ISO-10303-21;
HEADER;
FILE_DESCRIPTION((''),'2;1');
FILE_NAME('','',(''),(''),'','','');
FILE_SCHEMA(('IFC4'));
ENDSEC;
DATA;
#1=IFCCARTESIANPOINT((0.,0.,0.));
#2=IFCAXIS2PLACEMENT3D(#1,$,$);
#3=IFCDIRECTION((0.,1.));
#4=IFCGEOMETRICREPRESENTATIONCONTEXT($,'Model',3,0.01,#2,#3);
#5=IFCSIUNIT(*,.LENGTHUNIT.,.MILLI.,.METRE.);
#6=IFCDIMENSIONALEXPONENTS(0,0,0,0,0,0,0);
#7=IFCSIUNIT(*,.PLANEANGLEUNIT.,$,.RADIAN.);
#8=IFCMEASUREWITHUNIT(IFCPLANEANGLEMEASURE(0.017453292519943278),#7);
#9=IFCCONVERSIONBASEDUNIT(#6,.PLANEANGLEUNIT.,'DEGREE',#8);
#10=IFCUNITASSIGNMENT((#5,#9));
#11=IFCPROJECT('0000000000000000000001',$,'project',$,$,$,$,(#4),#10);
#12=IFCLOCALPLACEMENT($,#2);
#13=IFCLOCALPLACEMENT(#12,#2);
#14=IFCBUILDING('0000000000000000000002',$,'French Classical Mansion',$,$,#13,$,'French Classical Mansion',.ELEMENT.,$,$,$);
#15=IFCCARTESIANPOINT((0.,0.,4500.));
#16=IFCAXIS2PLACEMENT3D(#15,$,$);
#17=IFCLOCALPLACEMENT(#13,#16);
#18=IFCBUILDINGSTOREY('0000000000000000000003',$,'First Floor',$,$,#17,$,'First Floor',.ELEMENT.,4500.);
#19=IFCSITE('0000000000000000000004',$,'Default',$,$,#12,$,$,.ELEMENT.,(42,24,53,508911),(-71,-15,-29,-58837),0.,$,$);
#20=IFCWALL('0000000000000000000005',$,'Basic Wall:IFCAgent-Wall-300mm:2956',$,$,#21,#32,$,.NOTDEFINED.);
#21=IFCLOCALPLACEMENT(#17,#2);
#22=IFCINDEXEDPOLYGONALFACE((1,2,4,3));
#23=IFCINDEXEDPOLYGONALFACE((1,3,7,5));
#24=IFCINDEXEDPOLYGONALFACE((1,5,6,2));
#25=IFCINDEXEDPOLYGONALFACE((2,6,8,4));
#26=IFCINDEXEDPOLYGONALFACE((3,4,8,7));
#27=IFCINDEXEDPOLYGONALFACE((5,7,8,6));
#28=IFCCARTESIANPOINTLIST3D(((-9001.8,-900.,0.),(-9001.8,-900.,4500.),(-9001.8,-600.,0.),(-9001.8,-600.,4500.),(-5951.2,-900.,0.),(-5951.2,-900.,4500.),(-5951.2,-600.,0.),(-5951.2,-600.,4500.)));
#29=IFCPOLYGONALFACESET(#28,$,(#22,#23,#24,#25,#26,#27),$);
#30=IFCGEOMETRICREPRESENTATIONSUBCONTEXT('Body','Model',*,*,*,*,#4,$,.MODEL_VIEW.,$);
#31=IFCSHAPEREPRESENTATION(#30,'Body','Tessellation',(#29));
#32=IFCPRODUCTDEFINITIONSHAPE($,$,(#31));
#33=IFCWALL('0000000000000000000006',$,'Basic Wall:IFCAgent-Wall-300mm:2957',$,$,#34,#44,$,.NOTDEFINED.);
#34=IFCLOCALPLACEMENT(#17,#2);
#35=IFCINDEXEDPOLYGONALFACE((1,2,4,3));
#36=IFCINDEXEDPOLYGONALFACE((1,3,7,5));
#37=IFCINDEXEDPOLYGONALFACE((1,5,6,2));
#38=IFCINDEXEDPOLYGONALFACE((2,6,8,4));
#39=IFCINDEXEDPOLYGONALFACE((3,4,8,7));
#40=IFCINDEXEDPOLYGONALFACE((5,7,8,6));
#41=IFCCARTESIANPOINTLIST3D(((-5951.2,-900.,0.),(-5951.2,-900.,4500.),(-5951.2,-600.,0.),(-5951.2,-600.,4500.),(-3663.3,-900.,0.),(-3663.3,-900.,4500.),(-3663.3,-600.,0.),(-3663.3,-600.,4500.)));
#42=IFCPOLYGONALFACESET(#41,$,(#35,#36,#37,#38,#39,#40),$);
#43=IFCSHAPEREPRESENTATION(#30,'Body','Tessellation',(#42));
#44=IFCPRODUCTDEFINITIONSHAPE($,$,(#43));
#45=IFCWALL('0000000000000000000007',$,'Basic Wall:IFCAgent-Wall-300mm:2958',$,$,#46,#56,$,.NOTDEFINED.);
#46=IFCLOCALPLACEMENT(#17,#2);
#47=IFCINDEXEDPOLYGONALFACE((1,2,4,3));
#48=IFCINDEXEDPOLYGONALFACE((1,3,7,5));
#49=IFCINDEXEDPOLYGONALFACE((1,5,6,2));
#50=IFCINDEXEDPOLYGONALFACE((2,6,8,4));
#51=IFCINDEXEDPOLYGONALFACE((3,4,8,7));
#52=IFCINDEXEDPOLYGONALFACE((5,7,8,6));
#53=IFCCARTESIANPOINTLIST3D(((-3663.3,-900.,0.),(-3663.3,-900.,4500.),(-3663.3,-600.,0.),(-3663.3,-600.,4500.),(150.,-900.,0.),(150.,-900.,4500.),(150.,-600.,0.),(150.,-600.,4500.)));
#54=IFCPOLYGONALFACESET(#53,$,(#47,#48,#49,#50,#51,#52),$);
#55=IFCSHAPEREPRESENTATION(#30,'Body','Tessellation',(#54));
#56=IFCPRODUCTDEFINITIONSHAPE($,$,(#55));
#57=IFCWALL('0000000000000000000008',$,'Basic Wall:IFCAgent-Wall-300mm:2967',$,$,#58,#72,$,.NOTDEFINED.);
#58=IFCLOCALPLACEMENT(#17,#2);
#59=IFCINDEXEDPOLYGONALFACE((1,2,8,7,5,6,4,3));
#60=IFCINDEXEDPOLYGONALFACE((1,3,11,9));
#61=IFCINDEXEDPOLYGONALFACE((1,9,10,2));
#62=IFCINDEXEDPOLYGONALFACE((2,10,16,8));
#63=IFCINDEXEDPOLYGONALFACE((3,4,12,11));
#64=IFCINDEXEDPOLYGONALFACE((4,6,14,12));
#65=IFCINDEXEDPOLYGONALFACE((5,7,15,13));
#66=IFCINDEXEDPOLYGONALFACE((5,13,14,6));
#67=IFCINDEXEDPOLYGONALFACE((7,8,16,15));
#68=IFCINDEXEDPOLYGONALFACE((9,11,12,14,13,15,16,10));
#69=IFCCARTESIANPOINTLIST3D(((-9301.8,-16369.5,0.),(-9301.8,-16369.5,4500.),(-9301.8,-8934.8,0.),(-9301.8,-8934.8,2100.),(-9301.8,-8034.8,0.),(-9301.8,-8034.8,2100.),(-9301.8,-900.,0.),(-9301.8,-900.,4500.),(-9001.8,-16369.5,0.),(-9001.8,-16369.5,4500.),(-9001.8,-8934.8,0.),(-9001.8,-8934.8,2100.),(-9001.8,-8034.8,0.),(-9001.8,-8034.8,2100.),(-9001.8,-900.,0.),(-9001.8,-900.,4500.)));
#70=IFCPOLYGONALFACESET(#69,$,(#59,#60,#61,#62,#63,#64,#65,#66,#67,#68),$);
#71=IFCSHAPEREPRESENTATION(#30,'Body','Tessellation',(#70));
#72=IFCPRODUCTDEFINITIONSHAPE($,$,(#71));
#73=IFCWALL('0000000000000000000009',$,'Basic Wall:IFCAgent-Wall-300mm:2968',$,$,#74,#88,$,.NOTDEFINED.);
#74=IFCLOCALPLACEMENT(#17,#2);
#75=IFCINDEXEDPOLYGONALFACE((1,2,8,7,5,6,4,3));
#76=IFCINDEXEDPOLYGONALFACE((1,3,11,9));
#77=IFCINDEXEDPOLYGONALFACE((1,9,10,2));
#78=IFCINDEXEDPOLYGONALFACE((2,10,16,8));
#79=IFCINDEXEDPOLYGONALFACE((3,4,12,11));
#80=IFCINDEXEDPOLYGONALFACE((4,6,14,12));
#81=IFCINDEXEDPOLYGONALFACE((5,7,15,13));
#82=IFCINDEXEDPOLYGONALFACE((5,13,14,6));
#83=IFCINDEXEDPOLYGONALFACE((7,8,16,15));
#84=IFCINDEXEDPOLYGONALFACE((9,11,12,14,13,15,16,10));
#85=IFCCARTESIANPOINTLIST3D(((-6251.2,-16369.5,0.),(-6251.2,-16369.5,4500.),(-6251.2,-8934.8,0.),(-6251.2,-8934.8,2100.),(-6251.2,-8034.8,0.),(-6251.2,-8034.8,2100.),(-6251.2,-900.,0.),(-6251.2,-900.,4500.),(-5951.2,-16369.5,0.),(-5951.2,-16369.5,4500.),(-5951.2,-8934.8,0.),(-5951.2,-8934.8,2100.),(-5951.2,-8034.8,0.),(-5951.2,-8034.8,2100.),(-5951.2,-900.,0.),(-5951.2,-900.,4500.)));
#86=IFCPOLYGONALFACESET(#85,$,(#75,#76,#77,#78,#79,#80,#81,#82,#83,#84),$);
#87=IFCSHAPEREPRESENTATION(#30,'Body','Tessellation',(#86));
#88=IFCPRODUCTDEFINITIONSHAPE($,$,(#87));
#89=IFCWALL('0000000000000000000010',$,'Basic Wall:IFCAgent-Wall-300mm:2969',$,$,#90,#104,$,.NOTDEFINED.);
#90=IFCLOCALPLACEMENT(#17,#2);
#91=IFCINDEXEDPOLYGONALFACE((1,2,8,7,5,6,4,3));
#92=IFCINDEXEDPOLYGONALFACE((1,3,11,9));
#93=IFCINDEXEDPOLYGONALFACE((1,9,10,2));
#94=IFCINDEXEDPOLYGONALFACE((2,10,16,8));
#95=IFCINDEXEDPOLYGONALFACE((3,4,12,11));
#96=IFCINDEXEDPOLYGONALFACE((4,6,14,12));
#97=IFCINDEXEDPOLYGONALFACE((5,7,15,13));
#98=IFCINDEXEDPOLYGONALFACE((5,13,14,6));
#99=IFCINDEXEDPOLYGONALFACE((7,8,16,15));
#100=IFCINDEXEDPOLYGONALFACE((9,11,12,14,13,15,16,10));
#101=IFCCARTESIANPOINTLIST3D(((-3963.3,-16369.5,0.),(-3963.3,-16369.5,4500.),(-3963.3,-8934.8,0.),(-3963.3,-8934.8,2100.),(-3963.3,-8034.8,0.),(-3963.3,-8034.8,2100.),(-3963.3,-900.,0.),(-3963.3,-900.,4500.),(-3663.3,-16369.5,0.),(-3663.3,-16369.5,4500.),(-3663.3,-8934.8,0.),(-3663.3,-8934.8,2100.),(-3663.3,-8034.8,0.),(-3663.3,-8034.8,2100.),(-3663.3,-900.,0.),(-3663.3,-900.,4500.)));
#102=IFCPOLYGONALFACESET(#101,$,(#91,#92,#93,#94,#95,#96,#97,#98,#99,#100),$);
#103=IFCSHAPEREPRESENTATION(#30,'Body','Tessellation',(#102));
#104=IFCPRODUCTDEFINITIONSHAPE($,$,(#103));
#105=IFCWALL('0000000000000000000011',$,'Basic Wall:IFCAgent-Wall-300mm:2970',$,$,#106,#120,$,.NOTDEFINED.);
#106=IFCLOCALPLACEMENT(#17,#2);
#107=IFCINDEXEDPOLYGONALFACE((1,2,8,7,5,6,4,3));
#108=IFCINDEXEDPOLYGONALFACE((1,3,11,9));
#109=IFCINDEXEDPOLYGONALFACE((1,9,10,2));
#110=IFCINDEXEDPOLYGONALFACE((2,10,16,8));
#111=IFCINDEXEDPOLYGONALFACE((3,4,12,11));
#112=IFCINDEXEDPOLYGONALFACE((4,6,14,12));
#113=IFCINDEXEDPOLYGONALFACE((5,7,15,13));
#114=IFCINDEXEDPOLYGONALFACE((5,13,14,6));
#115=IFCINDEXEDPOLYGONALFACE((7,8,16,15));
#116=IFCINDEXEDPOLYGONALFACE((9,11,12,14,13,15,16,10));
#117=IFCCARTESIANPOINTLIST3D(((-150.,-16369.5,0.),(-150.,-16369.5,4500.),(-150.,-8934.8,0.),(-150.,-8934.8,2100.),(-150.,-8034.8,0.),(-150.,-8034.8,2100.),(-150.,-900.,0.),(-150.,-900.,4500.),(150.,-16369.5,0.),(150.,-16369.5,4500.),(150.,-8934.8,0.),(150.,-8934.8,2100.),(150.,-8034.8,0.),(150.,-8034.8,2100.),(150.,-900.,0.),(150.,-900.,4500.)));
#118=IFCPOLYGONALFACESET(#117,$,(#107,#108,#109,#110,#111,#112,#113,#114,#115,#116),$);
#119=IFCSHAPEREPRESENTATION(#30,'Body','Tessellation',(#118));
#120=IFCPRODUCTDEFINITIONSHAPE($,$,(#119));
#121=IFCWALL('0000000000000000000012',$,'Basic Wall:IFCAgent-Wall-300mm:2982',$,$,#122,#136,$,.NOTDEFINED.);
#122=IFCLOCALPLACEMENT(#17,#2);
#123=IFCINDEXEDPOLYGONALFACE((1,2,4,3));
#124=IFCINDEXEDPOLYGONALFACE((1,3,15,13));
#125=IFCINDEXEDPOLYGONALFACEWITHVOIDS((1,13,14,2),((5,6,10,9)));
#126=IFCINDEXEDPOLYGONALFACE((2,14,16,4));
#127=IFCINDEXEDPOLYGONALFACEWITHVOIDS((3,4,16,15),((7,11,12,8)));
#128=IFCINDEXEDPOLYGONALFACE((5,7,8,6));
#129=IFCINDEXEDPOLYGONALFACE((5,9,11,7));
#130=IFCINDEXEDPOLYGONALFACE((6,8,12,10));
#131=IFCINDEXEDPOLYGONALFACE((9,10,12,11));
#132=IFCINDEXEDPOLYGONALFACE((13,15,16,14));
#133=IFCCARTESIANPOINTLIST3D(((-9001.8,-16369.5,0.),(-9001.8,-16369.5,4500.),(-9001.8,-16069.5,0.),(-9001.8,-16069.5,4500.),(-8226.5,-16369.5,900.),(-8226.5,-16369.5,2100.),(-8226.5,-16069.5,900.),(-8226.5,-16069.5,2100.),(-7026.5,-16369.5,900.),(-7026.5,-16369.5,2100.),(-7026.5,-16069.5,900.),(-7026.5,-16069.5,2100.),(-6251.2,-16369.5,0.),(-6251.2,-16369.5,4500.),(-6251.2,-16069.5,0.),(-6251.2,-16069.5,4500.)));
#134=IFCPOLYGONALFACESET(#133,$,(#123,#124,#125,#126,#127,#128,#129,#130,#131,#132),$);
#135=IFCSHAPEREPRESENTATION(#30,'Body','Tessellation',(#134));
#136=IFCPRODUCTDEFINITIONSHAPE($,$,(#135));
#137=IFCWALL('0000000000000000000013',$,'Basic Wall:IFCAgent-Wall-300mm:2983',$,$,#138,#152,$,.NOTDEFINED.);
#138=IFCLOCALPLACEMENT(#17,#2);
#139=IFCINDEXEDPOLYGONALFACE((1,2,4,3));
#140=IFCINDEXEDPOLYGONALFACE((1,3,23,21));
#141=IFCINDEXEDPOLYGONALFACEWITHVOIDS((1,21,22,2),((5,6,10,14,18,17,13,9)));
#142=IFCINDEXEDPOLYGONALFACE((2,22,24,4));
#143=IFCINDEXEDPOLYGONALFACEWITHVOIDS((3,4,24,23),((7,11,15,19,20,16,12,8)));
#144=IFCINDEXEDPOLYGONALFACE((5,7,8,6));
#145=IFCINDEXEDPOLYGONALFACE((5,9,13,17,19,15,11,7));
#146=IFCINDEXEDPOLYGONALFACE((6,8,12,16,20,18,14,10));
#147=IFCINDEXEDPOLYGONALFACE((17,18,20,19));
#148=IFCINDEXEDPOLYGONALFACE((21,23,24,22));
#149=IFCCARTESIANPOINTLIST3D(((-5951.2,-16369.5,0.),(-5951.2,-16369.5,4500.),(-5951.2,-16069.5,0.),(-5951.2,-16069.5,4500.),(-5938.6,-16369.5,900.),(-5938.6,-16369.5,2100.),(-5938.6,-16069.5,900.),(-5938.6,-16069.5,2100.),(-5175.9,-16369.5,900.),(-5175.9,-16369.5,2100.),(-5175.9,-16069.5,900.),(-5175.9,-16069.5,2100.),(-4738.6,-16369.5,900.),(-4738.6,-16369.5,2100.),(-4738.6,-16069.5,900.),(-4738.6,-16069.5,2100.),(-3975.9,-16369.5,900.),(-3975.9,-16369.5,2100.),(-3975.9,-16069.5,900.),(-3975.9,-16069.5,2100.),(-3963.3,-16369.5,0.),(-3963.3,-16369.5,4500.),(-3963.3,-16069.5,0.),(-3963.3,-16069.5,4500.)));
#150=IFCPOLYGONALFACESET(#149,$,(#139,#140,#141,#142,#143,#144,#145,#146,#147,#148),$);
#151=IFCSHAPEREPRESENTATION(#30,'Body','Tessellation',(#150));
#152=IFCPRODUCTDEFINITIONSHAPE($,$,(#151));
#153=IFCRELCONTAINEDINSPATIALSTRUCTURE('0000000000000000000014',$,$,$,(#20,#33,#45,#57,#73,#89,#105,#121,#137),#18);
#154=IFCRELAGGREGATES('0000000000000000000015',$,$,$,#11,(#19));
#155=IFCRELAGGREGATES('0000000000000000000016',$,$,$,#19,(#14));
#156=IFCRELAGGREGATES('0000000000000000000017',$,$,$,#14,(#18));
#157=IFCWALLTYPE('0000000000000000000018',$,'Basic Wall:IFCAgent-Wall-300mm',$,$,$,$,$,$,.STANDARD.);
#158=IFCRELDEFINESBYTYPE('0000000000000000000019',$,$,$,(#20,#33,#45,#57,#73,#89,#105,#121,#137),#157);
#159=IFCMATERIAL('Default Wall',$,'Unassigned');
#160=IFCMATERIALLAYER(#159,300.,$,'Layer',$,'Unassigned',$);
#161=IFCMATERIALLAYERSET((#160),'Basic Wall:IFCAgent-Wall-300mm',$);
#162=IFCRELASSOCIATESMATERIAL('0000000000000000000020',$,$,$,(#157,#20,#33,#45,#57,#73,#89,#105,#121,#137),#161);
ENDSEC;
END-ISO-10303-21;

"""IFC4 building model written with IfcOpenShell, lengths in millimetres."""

from ifc_helpers import new_model, entity, si_unit, converted_unit, direction, frame, frame_2d, origin, place, context, subcontext, project, spatial, rectangle, extrude, material, layer, layer_set, layer_usage, type_object, element, save


model = new_model("IFC4")

# Units and contexts
model_context = context("Model", 3, precision=0.01, world=origin(), true_north=direction((0.0, 1.0)))
body_context = subcontext(model_context, "Body", "Model", "MODEL_VIEW")
ifc_project = project(units=[si_unit("LENGTHUNIT", "METRE", prefix="MILLI"), converted_unit("PLANEANGLEUNIT", "DEGREE", entity("IfcPlaneAngleMeasure", 0.017453292519943278), si_unit("PLANEANGLEUNIT", "RADIAN"), dimensions=[0, 0, 0, 0, 0, 0, 0])], contexts=[model_context])

# Site, building, storey
site_placement = place(None, origin())
site = spatial("IfcSite", under=ifc_project, at=site_placement, Name="Default", CompositionType="ELEMENT", RefLatitude=(42, 24, 53, 508911), RefLongitude=(-71, -15, -29, -58837), RefElevation=0.0)
building_placement = place(site_placement, origin())
building = spatial("IfcBuilding", under=site, at=building_placement, Name="French Classical Mansion", LongName="French Classical Mansion", CompositionType="ELEMENT")
storey_placement = place(building_placement, frame((0.0, 0.0, 4500.0)))
storey = spatial("IfcBuildingStorey", under=building, at=storey_placement, Name="First Floor", LongName="First Floor", CompositionType="ELEMENT", Elevation=4500.0)

# Walls
ifc_material = material(Name="Default Wall", Category="Unassigned")
ifc_layer = layer(ifc_material, 300.0, Name="Layer", Category="Unassigned")
ifc_layer_set = layer_set([ifc_layer], Name="Basic Wall:IFCAgent-Wall-300mm")
ifc_layer_usage_1 = layer_usage(ifc_layer_set, "AXIS2", "NEGATIVE", 150.0)
wall_type = type_object("IfcWallType", Name="Basic Wall:IFCAgent-Wall-300mm", PredefinedType="STANDARD", material=ifc_layer_set)
wall_1_placement = place(storey_placement, frame((-9001.8, -750.0, 0.0)))
element("IfcWall", 1, at=wall_1_placement, inside=storey, type_object=wall_type, material=ifc_layer_usage_1, Name="Basic Wall:IFCAgent-Wall-300mm:2956", PredefinedType="NOTDEFINED", context=body_context, shape_type="SweptSolid", body=[
    extrude(rectangle(XDim=3050.6, YDim=300.0, at=frame_2d((1525.3, 0.0), x_axis=(-1.0, 0.0))), origin(), (0.0, 0.0, 1.0), 4500.0),
])
ifc_layer_usage_2 = layer_usage(ifc_layer_set, "AXIS2", "NEGATIVE", 150.0)
wall_2_placement = place(storey_placement, frame((-5951.2, -750.0, 0.0)))
element("IfcWall", 2, at=wall_2_placement, inside=storey, type_object=wall_type, material=ifc_layer_usage_2, Name="Basic Wall:IFCAgent-Wall-300mm:2957", PredefinedType="NOTDEFINED", context=body_context, shape_type="SweptSolid", body=[
    extrude(rectangle(XDim=2288.0, YDim=300.0, at=frame_2d((1144.0, 0.0), x_axis=(-1.0, 0.0))), origin(), (0.0, 0.0, 1.0), 4500.0),
])
ifc_layer_usage_3 = layer_usage(ifc_layer_set, "AXIS2", "NEGATIVE", 150.0)
wall_3_placement = place(storey_placement, frame((-3663.3, -750.0, 0.0)))
element("IfcWall", 3, at=wall_3_placement, inside=storey, type_object=wall_type, material=ifc_layer_usage_3, Name="Basic Wall:IFCAgent-Wall-300mm:2958", PredefinedType="NOTDEFINED", context=body_context, shape_type="SweptSolid", body=[
    extrude(rectangle(XDim=3813.3, YDim=300.0, at=frame_2d((1906.6, 0.0), x_axis=(-1.0, 0.0))), origin(), (0.0, 0.0, 1.0), 4500.0),
])

# Walls, openings
ifc_layer_usage_4 = layer_usage(ifc_layer_set, "AXIS2", "NEGATIVE", 150.0)
wall_4_placement = place(storey_placement, frame((-9151.8, -16369.5, 0.0), z_axis=(0.0, 0.0, 1.0), x_axis=(0.0, 1.0, 0.0)))
wall_4 = element("IfcWall", 4, at=wall_4_placement, inside=storey, type_object=wall_type, material=ifc_layer_usage_4, Name="Basic Wall:IFCAgent-Wall-300mm:2967", PredefinedType="NOTDEFINED", context=body_context, shape_type="SweptSolid", body=[
    extrude(rectangle(XDim=15469.5, YDim=300.0, at=frame_2d((7734.8, 0.0), x_axis=(1.0, 0.0))), origin(), (0.0, 0.0, 1.0), 4500.0),
])
opening_1_placement = place(wall_4_placement, origin())
element("IfcOpeningElement", 5, at=opening_1_placement, cuts=wall_4, PredefinedType="OPENING", context=body_context, shape_type="SweptSolid", body=[
    extrude(rectangle(XDim=2100.0, YDim=900.0, at=frame_2d((0.0, 0.0), x_axis=(1.0, 0.0))), frame((7884.7, -150.0, 1050.0), z_axis=(0.0, 1.0, 0.0), x_axis=(0.0, 0.0, -1.0)), (0.0, 0.0, 1.0), 300.0),
])
ifc_layer_usage_5 = layer_usage(ifc_layer_set, "AXIS2", "NEGATIVE", 150.0)
wall_5_placement = place(storey_placement, frame((-6101.2, -16369.5, 0.0), z_axis=(0.0, 0.0, 1.0), x_axis=(0.0, 1.0, 0.0)))
wall_5 = element("IfcWall", 6, at=wall_5_placement, inside=storey, type_object=wall_type, material=ifc_layer_usage_5, Name="Basic Wall:IFCAgent-Wall-300mm:2968", PredefinedType="NOTDEFINED", context=body_context, shape_type="SweptSolid", body=[
    extrude(rectangle(XDim=15469.5, YDim=300.0, at=frame_2d((7734.8, 0.0), x_axis=(1.0, 0.0))), origin(), (0.0, 0.0, 1.0), 4500.0),
])
opening_2_placement = place(wall_5_placement, origin())
element("IfcOpeningElement", 7, at=opening_2_placement, cuts=wall_5, PredefinedType="OPENING", context=body_context, shape_type="SweptSolid", body=[
    extrude(rectangle(XDim=2100.0, YDim=900.0, at=frame_2d((0.0, 0.0), x_axis=(1.0, 0.0))), frame((7884.7, -150.0, 1050.0), z_axis=(0.0, 1.0, 0.0), x_axis=(0.0, 0.0, -1.0)), (0.0, 0.0, 1.0), 300.0),
])
ifc_layer_usage_6 = layer_usage(ifc_layer_set, "AXIS2", "NEGATIVE", 150.0)
wall_6_placement = place(storey_placement, frame((-3813.3, -16369.5, 0.0), z_axis=(0.0, 0.0, 1.0), x_axis=(0.0, 1.0, 0.0)))
wall_6 = element("IfcWall", 8, at=wall_6_placement, inside=storey, type_object=wall_type, material=ifc_layer_usage_6, Name="Basic Wall:IFCAgent-Wall-300mm:2969", PredefinedType="NOTDEFINED", context=body_context, shape_type="SweptSolid", body=[
    extrude(rectangle(XDim=15469.5, YDim=300.0, at=frame_2d((7734.8, 0.0), x_axis=(1.0, 0.0))), origin(), (0.0, 0.0, 1.0), 4500.0),
])
opening_3_placement = place(wall_6_placement, origin())
element("IfcOpeningElement", 9, at=opening_3_placement, cuts=wall_6, PredefinedType="OPENING", context=body_context, shape_type="SweptSolid", body=[
    extrude(rectangle(XDim=2100.0, YDim=900.0, at=frame_2d((0.0, 0.0), x_axis=(1.0, 0.0))), frame((7884.7, -150.0, 1050.0), z_axis=(0.0, 1.0, 0.0), x_axis=(0.0, 0.0, -1.0)), (0.0, 0.0, 1.0), 300.0),
])
ifc_layer_usage_7 = layer_usage(ifc_layer_set, "AXIS2", "NEGATIVE", 150.0)
wall_7_placement = place(storey_placement, frame((0.0, -16369.5, 0.0), z_axis=(0.0, 0.0, 1.0), x_axis=(0.0, 1.0, 0.0)))
wall_7 = element("IfcWall", 10, at=wall_7_placement, inside=storey, type_object=wall_type, material=ifc_layer_usage_7, Name="Basic Wall:IFCAgent-Wall-300mm:2970", PredefinedType="NOTDEFINED", context=body_context, shape_type="SweptSolid", body=[
    extrude(rectangle(XDim=15469.5, YDim=300.0, at=frame_2d((7734.8, 0.0), x_axis=(1.0, 0.0))), origin(), (0.0, 0.0, 1.0), 4500.0),
])
opening_4_placement = place(wall_7_placement, origin())
element("IfcOpeningElement", 11, at=opening_4_placement, cuts=wall_7, PredefinedType="OPENING", context=body_context, shape_type="SweptSolid", body=[
    extrude(rectangle(XDim=2100.0, YDim=900.0, at=frame_2d((0.0, 0.0), x_axis=(1.0, 0.0))), frame((7884.7, -150.0, 1050.0), z_axis=(0.0, 1.0, 0.0), x_axis=(0.0, 0.0, -1.0)), (0.0, 0.0, 1.0), 300.0),
])
ifc_layer_usage_8 = layer_usage(ifc_layer_set, "AXIS2", "NEGATIVE", 150.0)
wall_8_placement = place(storey_placement, frame((-9001.8, -16219.5, 0.0)))
wall_8 = element("IfcWall", 12, at=wall_8_placement, inside=storey, type_object=wall_type, material=ifc_layer_usage_8, Name="Basic Wall:IFCAgent-Wall-300mm:2982", PredefinedType="NOTDEFINED", context=body_context, shape_type="SweptSolid", body=[
    extrude(rectangle(XDim=2750.6, YDim=300.0, at=frame_2d((1375.3, 0.0), x_axis=(-1.0, 0.0))), origin(), (0.0, 0.0, 1.0), 4500.0),
])
opening_5_placement = place(wall_8_placement, origin())
element("IfcOpeningElement", 13, at=opening_5_placement, cuts=wall_8, PredefinedType="OPENING", context=body_context, shape_type="SweptSolid", body=[
    extrude(rectangle(XDim=1200.0, YDim=1200.0, at=frame_2d((0.0, 0.0), x_axis=(1.0, 0.0))), frame((1375.3, -150.0, 1500.0), z_axis=(0.0, 1.0, 0.0), x_axis=(0.0, 0.0, -1.0)), (0.0, 0.0, 1.0), 300.0),
])

# Wall, openings
ifc_layer_usage_9 = layer_usage(ifc_layer_set, "AXIS2", "NEGATIVE", 150.0)
wall_9_placement = place(storey_placement, frame((-5951.2, -16219.5, 0.0)))
wall_9 = element("IfcWall", 14, at=wall_9_placement, inside=storey, type_object=wall_type, material=ifc_layer_usage_9, Name="Basic Wall:IFCAgent-Wall-300mm:2983", PredefinedType="NOTDEFINED", context=body_context, shape_type="SweptSolid", body=[
    extrude(rectangle(XDim=1988.0, YDim=300.0, at=frame_2d((994.0, 0.0), x_axis=(-1.0, 0.0))), origin(), (0.0, 0.0, 1.0), 4500.0),
])
opening_6_placement = place(wall_9_placement, origin())
element("IfcOpeningElement", 15, at=opening_6_placement, cuts=wall_9, PredefinedType="OPENING", context=body_context, shape_type="SweptSolid", body=[
    extrude(rectangle(XDim=1200.0, YDim=1200.0, at=frame_2d((0.0, 0.0), x_axis=(1.0, 0.0))), frame((612.7, -150.0, 1500.0), z_axis=(0.0, 1.0, 0.0), x_axis=(0.0, 0.0, -1.0)), (0.0, 0.0, 1.0), 300.0),
])
opening_7_placement = place(wall_9_placement, origin())
element("IfcOpeningElement", 16, at=opening_7_placement, cuts=wall_9, PredefinedType="OPENING", context=body_context, shape_type="SweptSolid", body=[
    extrude(rectangle(XDim=1200.0, YDim=1200.0, at=frame_2d((0.0, 0.0), x_axis=(1.0, 0.0))), frame((1375.3, -150.0, 1500.0), z_axis=(0.0, 1.0, 0.0), x_axis=(0.0, 0.0, -1.0)), (0.0, 0.0, 1.0), 300.0),
])

save(model, "model.ifc")
